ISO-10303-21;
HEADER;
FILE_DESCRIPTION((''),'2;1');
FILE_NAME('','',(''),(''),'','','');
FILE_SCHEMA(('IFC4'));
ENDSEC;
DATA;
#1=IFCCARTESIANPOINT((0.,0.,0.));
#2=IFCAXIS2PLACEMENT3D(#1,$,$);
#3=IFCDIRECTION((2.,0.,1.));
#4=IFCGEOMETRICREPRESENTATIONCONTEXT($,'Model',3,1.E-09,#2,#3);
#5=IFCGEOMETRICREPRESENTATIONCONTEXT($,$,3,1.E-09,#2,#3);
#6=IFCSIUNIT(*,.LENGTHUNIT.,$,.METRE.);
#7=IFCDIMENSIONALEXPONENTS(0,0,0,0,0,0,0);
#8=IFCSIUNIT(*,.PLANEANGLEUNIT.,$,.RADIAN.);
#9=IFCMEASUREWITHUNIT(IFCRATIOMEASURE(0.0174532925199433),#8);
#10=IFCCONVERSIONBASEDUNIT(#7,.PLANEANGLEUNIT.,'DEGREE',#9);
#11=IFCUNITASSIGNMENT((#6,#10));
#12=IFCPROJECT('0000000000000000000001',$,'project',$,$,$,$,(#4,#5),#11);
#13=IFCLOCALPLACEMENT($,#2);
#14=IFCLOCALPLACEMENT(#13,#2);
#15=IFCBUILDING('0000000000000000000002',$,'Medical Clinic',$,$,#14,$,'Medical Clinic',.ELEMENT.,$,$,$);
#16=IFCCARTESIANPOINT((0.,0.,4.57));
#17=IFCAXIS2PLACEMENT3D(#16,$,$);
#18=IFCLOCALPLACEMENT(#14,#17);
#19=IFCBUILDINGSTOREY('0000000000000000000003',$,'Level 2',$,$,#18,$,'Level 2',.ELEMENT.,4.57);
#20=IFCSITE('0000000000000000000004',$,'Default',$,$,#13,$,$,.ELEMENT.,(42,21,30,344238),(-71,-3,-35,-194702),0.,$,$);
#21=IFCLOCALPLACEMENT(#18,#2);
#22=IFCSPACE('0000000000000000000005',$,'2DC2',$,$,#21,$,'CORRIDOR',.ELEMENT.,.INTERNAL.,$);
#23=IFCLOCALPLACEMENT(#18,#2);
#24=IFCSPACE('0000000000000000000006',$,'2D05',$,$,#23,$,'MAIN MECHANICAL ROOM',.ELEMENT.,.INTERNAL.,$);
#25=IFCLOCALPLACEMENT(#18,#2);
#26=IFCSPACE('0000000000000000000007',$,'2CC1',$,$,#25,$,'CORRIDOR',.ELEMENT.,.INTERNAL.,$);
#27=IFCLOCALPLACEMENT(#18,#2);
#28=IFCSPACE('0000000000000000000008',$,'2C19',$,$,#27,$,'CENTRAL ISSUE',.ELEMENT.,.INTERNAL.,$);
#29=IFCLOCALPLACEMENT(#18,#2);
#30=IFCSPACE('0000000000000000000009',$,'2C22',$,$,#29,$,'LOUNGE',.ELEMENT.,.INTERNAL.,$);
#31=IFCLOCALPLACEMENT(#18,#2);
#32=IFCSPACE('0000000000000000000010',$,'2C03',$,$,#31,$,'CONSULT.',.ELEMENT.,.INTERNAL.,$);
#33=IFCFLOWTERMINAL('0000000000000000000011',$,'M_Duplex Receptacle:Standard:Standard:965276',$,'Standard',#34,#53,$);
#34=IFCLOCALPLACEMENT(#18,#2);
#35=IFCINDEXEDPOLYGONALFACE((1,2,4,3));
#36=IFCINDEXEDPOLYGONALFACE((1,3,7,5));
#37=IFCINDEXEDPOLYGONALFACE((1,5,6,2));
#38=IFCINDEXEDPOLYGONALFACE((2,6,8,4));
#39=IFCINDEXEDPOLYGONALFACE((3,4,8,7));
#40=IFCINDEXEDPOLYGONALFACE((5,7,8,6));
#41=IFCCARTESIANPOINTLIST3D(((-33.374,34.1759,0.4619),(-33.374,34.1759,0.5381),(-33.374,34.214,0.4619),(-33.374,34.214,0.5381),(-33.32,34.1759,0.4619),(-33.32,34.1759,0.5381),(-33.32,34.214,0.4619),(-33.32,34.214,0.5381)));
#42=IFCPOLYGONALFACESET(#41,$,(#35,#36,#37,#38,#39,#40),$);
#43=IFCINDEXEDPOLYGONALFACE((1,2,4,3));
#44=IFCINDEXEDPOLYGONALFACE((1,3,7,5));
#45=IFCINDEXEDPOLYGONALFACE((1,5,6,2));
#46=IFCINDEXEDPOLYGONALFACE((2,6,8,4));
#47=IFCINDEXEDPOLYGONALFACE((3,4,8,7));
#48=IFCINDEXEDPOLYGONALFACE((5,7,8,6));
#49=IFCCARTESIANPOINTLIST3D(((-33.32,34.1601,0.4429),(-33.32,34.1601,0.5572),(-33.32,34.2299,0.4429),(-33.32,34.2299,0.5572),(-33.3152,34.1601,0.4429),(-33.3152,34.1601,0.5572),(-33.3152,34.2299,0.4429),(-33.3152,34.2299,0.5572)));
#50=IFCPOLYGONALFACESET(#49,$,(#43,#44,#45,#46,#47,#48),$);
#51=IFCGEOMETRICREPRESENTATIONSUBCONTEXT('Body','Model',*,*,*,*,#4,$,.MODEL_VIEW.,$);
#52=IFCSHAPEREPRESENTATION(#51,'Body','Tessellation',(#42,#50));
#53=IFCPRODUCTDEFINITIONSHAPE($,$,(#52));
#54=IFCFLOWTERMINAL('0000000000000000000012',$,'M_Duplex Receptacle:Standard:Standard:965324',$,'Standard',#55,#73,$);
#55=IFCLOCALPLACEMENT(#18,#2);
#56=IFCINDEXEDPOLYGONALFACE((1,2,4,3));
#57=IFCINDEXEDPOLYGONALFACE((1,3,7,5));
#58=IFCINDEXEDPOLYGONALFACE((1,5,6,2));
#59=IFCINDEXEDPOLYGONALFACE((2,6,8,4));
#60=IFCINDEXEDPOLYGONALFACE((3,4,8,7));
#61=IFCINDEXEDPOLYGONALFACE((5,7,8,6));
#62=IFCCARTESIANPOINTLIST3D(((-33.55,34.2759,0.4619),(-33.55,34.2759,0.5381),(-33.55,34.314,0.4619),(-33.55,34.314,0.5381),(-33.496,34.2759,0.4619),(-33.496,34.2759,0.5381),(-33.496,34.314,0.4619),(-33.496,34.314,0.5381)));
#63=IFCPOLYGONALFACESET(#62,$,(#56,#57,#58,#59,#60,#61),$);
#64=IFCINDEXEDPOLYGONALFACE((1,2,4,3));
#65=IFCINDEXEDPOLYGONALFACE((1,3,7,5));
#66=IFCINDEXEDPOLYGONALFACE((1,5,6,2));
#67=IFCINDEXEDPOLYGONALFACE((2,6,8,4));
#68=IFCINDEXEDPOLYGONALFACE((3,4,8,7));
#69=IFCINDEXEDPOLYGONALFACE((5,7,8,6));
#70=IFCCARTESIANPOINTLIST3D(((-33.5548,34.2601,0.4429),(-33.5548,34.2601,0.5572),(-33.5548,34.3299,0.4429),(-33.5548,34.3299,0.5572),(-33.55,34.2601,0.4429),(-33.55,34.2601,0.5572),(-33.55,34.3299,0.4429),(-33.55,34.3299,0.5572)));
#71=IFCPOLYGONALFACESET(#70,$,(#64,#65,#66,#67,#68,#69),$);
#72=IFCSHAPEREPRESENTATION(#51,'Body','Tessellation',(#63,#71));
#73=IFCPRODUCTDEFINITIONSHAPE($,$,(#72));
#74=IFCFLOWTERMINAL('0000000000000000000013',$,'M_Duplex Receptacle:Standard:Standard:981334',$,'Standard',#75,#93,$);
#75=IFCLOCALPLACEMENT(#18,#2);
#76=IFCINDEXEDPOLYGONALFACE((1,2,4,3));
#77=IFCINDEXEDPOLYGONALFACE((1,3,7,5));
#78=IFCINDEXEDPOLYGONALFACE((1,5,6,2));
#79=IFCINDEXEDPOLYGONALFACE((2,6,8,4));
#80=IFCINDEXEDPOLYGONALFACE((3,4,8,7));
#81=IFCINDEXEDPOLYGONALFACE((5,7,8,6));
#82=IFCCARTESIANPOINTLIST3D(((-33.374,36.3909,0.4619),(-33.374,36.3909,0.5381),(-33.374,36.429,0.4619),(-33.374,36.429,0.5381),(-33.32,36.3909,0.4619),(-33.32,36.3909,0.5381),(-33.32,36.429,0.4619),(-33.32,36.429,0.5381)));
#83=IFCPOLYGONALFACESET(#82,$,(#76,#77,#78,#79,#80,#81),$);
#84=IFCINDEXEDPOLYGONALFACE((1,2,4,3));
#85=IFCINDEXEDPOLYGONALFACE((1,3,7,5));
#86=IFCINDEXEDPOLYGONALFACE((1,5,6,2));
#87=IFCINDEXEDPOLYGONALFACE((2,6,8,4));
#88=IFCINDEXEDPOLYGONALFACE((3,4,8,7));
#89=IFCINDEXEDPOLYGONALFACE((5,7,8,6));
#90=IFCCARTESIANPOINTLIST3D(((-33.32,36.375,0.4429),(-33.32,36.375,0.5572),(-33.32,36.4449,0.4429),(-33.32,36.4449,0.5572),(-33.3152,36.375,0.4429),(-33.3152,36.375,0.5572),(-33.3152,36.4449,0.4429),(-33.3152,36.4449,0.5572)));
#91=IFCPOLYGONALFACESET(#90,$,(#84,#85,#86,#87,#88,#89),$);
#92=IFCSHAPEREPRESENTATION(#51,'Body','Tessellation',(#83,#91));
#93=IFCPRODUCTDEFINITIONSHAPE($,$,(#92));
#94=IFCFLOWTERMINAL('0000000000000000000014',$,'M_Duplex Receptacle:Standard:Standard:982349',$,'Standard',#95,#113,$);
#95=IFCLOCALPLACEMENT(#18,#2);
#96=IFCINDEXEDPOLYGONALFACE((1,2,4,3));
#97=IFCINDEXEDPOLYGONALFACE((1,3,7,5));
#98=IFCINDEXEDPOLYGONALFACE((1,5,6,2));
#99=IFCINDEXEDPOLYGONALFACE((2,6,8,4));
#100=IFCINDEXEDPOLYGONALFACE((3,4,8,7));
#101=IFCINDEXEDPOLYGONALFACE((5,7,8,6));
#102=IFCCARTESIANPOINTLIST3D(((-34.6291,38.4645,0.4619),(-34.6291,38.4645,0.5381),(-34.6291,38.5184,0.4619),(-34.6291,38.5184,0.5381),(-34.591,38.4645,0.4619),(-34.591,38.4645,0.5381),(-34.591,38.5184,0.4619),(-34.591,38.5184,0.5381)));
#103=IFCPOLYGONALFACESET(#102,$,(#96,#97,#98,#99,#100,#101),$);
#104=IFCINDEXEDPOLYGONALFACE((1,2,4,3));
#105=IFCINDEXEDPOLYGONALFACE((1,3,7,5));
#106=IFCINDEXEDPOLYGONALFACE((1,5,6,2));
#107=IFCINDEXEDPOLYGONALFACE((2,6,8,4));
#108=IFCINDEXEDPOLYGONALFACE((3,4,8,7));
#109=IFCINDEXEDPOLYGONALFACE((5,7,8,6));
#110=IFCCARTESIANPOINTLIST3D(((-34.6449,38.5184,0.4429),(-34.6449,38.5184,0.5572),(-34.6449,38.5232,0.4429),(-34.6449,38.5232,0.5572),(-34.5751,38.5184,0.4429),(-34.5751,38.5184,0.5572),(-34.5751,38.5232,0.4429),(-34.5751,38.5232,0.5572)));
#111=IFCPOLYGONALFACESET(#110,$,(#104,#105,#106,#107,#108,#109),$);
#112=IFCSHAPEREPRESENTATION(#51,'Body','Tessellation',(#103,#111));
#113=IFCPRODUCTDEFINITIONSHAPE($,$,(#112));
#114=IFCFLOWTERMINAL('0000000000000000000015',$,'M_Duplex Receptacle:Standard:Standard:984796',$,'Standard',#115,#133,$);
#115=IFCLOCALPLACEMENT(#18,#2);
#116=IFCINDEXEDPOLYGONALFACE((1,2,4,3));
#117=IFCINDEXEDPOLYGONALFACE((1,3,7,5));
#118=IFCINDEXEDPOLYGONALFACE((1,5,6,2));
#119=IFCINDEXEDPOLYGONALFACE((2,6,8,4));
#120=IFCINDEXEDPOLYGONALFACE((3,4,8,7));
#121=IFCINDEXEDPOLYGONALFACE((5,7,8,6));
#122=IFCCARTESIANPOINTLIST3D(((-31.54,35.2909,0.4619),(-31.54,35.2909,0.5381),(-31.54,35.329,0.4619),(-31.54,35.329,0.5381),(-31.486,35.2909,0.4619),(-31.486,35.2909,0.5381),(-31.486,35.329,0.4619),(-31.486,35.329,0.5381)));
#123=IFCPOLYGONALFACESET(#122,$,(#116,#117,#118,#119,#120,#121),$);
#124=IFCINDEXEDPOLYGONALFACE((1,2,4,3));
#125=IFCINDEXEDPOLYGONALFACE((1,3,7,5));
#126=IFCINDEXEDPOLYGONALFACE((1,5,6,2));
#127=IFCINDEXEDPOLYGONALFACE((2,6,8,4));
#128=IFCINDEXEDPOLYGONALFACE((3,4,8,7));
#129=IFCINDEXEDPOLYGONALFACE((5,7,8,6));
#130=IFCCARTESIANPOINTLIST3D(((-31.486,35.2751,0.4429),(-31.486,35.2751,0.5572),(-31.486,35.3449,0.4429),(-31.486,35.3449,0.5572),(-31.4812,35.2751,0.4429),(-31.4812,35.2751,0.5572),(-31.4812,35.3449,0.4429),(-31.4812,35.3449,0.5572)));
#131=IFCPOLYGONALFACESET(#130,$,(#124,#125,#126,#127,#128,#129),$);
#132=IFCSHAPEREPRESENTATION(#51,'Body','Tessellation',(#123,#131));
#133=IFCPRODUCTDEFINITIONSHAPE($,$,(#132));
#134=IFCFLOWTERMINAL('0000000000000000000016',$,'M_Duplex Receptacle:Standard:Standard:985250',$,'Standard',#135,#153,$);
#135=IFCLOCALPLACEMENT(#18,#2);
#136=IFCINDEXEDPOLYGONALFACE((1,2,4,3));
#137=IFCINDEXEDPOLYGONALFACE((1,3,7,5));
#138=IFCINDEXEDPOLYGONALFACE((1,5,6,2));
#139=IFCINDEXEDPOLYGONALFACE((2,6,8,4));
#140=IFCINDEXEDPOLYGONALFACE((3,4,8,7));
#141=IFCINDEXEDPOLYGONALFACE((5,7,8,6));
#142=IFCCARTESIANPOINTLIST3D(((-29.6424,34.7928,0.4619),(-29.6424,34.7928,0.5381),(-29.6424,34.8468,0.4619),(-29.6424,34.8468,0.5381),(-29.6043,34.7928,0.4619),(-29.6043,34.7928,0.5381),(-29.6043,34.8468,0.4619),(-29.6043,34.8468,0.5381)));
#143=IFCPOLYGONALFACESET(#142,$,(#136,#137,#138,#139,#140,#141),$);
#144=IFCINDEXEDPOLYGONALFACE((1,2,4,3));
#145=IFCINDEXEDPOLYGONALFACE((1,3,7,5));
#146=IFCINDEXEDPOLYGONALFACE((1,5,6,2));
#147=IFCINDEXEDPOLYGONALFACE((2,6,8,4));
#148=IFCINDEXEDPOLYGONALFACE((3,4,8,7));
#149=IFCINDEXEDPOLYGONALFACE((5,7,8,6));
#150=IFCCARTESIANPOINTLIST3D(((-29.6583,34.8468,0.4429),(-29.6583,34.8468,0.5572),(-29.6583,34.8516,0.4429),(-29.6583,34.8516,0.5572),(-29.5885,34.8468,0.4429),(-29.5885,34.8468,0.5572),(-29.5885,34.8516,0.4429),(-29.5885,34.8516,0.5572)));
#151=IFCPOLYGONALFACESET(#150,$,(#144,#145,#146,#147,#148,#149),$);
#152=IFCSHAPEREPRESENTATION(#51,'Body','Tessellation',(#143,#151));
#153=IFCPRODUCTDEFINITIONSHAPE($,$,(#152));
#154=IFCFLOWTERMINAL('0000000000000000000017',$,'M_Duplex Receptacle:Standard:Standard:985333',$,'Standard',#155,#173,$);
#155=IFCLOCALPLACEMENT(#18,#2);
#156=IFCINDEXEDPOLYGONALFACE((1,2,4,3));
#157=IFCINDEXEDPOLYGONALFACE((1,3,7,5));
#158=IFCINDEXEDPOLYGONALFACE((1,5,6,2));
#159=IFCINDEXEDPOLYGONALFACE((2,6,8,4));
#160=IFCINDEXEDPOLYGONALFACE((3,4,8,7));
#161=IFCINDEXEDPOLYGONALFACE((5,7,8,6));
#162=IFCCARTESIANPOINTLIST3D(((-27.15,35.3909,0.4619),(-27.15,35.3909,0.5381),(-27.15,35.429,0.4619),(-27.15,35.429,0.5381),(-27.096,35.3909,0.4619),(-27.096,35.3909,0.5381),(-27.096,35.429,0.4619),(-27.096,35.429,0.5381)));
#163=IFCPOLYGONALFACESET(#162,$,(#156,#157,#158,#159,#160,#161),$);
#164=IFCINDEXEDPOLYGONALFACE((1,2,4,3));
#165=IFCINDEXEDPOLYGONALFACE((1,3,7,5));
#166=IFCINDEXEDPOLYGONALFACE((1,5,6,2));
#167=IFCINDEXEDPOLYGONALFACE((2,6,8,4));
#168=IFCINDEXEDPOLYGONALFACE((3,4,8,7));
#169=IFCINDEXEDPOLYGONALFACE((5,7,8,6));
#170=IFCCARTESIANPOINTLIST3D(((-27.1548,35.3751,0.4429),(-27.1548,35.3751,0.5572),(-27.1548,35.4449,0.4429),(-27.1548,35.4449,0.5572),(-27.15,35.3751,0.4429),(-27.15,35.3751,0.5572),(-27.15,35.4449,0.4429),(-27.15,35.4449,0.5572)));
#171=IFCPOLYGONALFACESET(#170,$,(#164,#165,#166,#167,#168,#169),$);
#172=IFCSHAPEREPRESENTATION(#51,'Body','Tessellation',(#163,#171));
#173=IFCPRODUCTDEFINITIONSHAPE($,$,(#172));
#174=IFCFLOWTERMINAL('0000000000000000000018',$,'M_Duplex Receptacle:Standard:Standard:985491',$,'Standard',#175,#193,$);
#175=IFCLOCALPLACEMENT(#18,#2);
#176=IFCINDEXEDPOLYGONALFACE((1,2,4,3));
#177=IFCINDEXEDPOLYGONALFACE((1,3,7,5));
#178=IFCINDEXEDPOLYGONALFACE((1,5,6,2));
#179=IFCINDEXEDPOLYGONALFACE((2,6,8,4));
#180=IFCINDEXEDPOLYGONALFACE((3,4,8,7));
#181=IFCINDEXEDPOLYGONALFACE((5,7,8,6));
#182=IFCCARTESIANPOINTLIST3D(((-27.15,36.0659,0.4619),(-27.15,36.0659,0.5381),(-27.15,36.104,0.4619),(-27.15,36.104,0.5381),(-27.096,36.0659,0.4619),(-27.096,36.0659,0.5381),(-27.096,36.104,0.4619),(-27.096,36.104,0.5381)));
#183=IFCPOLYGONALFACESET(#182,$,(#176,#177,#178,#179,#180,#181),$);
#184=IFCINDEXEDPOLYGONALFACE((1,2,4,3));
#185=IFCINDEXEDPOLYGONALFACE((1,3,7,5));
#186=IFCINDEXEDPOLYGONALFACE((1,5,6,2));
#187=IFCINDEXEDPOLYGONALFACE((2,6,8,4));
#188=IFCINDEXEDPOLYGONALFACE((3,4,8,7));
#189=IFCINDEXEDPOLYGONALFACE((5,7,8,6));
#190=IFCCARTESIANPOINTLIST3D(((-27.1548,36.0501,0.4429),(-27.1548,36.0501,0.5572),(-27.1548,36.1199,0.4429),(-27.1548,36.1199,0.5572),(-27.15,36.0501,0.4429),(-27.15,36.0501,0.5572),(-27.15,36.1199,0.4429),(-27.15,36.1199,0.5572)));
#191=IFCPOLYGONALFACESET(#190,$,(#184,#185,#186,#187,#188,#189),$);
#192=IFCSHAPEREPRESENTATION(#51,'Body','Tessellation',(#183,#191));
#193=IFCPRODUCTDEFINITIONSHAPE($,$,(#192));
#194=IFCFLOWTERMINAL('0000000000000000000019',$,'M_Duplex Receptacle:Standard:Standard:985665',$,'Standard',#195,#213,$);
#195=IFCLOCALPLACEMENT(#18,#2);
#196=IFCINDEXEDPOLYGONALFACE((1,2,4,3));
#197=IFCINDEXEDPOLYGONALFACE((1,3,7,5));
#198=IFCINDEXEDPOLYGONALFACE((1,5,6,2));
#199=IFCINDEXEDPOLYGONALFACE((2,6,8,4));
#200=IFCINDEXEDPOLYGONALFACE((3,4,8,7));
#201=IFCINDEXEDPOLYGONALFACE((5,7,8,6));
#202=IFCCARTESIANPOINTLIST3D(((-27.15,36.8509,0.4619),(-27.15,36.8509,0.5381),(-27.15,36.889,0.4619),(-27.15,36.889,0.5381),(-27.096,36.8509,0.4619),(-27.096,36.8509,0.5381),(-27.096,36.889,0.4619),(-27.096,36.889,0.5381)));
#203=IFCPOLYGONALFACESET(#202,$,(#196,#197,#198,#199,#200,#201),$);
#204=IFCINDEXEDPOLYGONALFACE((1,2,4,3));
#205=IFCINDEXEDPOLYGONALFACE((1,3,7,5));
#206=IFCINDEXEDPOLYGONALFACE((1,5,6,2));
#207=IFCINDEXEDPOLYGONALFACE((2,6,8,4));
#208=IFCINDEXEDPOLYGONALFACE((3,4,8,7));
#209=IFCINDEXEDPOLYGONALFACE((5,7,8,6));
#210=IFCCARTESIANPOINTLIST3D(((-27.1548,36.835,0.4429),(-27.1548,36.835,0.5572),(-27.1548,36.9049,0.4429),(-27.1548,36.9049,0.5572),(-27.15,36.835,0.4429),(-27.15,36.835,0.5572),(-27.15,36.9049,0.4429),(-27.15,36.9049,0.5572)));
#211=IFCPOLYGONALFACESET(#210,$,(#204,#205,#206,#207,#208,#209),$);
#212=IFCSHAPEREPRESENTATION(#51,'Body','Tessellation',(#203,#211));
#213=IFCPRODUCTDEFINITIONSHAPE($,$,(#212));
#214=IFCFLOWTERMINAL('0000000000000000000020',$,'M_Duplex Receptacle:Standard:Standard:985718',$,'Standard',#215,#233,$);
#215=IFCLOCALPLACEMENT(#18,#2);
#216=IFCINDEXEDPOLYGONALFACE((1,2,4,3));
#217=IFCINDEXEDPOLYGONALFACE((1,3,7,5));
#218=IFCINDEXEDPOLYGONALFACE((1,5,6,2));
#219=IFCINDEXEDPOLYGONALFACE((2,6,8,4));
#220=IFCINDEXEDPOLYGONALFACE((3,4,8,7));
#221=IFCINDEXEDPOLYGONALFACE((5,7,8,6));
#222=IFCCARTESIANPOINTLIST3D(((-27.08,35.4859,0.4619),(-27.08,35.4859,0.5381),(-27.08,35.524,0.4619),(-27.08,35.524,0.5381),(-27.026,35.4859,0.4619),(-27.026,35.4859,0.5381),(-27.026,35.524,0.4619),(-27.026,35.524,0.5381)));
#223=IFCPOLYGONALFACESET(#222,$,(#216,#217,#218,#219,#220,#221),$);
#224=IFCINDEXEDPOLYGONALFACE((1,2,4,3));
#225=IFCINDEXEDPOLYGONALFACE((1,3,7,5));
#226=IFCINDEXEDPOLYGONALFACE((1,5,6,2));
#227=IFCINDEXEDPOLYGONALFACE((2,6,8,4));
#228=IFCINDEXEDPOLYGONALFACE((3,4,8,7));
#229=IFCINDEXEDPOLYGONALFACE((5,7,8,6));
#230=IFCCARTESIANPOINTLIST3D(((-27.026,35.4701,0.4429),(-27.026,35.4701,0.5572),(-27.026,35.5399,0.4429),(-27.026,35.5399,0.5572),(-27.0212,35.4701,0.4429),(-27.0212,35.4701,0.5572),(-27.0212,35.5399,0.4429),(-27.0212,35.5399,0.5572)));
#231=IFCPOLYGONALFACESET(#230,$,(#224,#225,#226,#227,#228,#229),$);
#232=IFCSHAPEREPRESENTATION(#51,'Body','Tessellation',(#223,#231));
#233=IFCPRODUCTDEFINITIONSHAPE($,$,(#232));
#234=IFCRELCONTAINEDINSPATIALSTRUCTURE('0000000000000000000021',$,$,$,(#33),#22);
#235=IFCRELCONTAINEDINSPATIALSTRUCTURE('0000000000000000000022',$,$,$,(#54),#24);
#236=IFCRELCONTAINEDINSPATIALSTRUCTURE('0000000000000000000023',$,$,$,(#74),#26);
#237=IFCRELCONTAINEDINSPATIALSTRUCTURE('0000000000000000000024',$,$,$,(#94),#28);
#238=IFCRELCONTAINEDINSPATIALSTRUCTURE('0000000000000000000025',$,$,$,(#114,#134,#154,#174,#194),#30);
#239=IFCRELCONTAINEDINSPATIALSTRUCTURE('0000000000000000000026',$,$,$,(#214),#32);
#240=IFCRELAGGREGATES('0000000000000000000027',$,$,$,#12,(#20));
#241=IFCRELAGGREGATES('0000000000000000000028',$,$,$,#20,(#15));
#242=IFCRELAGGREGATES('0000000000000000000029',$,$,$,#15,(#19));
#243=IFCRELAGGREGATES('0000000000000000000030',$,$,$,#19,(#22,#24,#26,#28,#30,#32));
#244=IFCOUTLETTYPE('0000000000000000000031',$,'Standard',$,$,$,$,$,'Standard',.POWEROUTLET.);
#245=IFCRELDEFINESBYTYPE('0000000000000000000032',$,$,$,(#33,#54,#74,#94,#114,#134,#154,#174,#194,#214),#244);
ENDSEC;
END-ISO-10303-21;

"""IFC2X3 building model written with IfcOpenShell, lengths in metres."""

from ifc_helpers import new_model, entity, si_unit, converted_unit, direction, frame, frame_2d, origin, origin_2d_with_axis, place, context, subcontext, project, spatial, rectangle, extrude, source, transform, mapped, type_object, type_shapes, element, save


model = new_model("IFC2X3")

# Units and contexts
model_context = context("Model", 3, precision=1e-09, world=origin(), true_north=direction((2.0, 0.0, 1.0)))
context_of_model = context(None, 3, precision=1e-09, world=origin(), true_north=direction((2.0, 0.0, 1.0)))
body_context = subcontext(model_context, "Body", "Model", "MODEL_VIEW")
ifc_project = project(units=[si_unit("LENGTHUNIT", "METRE"), converted_unit("PLANEANGLEUNIT", "DEGREE", entity("IfcRatioMeasure", 0.0174532925199433), si_unit("PLANEANGLEUNIT", "RADIAN"), dimensions=[0, 0, 0, 0, 0, 0, 0])], contexts=[model_context, context_of_model])

# Site, building, storey, space
site_placement = place(None, origin())
site = spatial("IfcSite", under=ifc_project, at=site_placement, Name="Default", CompositionType="ELEMENT", RefLatitude=(42, 21, 30, 344238), RefLongitude=(-71, -3, -35, -194702), RefElevation=0.0)
building_placement = place(site_placement, origin())
building = spatial("IfcBuilding", under=site, at=building_placement, Name="Medical Clinic", LongName="Medical Clinic", CompositionType="ELEMENT")
storey_placement = place(building_placement, frame((0.0, 0.0, 4.57)))
storey = spatial("IfcBuildingStorey", under=building, at=storey_placement, Name="Level 2", LongName="Level 2", CompositionType="ELEMENT", Elevation=4.57)
space_1_placement = place(storey_placement, origin())
space_1 = spatial("IfcSpace", under=storey, at=space_1_placement, Name="2DC2", LongName="CORRIDOR", CompositionType="ELEMENT", InteriorOrExteriorSpace="INTERNAL")

# Flow terminal
outlet_type = type_object("IfcOutletType", Name="Standard", ElementType="Standard", PredefinedType="POWEROUTLET")
shared_shape_1 = source(origin(), body_context, "Body", "SweptSolid", [
    extrude(rectangle(XDim=0.0381, YDim=0.0762, at=origin_2d_with_axis()), frame((0.0, 0.0, -0.054), z_axis=(0.0, 0.0, 1.0), x_axis=(-1.0, 0.0, 0.0)), (0.0, 0.0, 1.0), 0.054),
    extrude(rectangle(XDim=0.0698, YDim=0.1143, at=frame_2d((0.0, 0.0), x_axis=(1.0, 0.0))), frame((0.0, 0.0, 0.0), z_axis=(0.0, 0.0, 1.0), x_axis=(-1.0, 0.0, 0.0)), (0.0, 0.0, 1.0), 0.0048),
])
type_shapes(outlet_type, [shared_shape_1])
flow_terminal_1_placement = place(space_1_placement, frame((-33.32, 34.195, 0.5), z_axis=(1.0, 0.0, 0.0), x_axis=(0.0, 1.0, 0.0)))
element("IfcFlowTerminal", 1, at=flow_terminal_1_placement, inside=space_1, type_object=outlet_type, Name="M_Duplex Receptacle:Standard:Standard:965276", ObjectType="Standard", context=body_context, shape_type="MappedRepresentation", body=[
    mapped(shared_shape_1, transform((0.0, 0.0, 0.0), scale=1.0)),
])

# Shared definitions
space_2_placement = place(storey_placement, origin())
space_2 = spatial("IfcSpace", under=storey, at=space_2_placement, Name="2D05", LongName="MAIN MECHANICAL ROOM", CompositionType="ELEMENT", InteriorOrExteriorSpace="INTERNAL")

# Flow terminal
flow_terminal_2_placement = place(space_2_placement, frame((-33.55, 34.295, 0.5), z_axis=(-1.0, 0.0, 0.0), x_axis=(0.0, -1.0, 0.0)))
element("IfcFlowTerminal", 2, at=flow_terminal_2_placement, inside=space_2, type_object=outlet_type, Name="M_Duplex Receptacle:Standard:Standard:965324", ObjectType="Standard", context=body_context, shape_type="MappedRepresentation", body=[
    mapped(shared_shape_1, transform((0.0, 0.0, 0.0), scale=1.0)),
])

# Shared definitions
space_3_placement = place(storey_placement, origin())
space_3 = spatial("IfcSpace", under=storey, at=space_3_placement, Name="2CC1", LongName="CORRIDOR", CompositionType="ELEMENT", InteriorOrExteriorSpace="INTERNAL")

# Flow terminal
flow_terminal_3_placement = place(space_3_placement, frame((-33.32, 36.4099, 0.5), z_axis=(1.0, 0.0, 0.0), x_axis=(0.0, 1.0, 0.0)))
element("IfcFlowTerminal", 3, at=flow_terminal_3_placement, inside=space_3, type_object=outlet_type, Name="M_Duplex Receptacle:Standard:Standard:981334", ObjectType="Standard", context=body_context, shape_type="MappedRepresentation", body=[
    mapped(shared_shape_1, transform((0.0, 0.0, 0.0), scale=1.0)),
])

# Shared definitions
space_4_placement = place(storey_placement, origin())
space_4 = spatial("IfcSpace", under=storey, at=space_4_placement, Name="2C19", LongName="CENTRAL ISSUE", CompositionType="ELEMENT", InteriorOrExteriorSpace="INTERNAL")

# Flow terminal
flow_terminal_4_placement = place(space_4_placement, frame((-34.61, 38.5184, 0.5), z_axis=(0.0, 1.0, 0.0), x_axis=(-1.0, 0.0, 0.0)))
element("IfcFlowTerminal", 4, at=flow_terminal_4_placement, inside=space_4, type_object=outlet_type, Name="M_Duplex Receptacle:Standard:Standard:982349", ObjectType="Standard", context=body_context, shape_type="MappedRepresentation", body=[
    mapped(shared_shape_1, transform((0.0, 0.0, 0.0), scale=1.0)),
])

# Shared definitions
space_5_placement = place(storey_placement, origin())
space_5 = spatial("IfcSpace", under=storey, at=space_5_placement, Name="2C22", LongName="LOUNGE", CompositionType="ELEMENT", InteriorOrExteriorSpace="INTERNAL")

# Flow terminals
for number, where, z_axis, x_axis, name in (
    (5, (-31.486, 35.31, 0.5), (1.0, 0.0, 0.0), (0.0, 1.0, 0.0), "M_Duplex Receptacle:Standard:Standard:984796"),
    (6, (-29.6234, 34.8468, 0.5), (0.0, 1.0, 0.0), (-1.0, 0.0, 0.0), "M_Duplex Receptacle:Standard:Standard:985250"),
    (7, (-27.15, 35.41, 0.5), (-1.0, 0.0, 0.0), (0.0, -1.0, 0.0), "M_Duplex Receptacle:Standard:Standard:985333"),
    (8, (-27.15, 36.085, 0.5), (-1.0, 0.0, 0.0), (0.0, -1.0, 0.0), "M_Duplex Receptacle:Standard:Standard:985491"),
    (9, (-27.15, 36.8699, 0.5), (-1.0, 0.0, 0.0), (0.0, -1.0, 0.0), "M_Duplex Receptacle:Standard:Standard:985665"),
):
    element("IfcFlowTerminal", number, at=place(space_5_placement, frame(where, z_axis=z_axis, x_axis=x_axis)), inside=space_5, type_object=outlet_type, Name=name, ObjectType="Standard", context=body_context, shape_type="MappedRepresentation", body=[
        mapped(shared_shape_1, transform((0.0, 0.0, 0.0), scale=1.0)),
    ])

# Shared definitions
space_6_placement = place(storey_placement, origin())
space_6 = spatial("IfcSpace", under=storey, at=space_6_placement, Name="2C03", LongName="CONSULT.", CompositionType="ELEMENT", InteriorOrExteriorSpace="INTERNAL")

# Flow terminal
for number, where, z_axis, x_axis, name in (
    (10, (-27.026, 35.505, 0.5), (1.0, 0.0, 0.0), (0.0, 1.0, 0.0), "M_Duplex Receptacle:Standard:Standard:985718"),
):
    element("IfcFlowTerminal", number, at=place(space_6_placement, frame(where, z_axis=z_axis, x_axis=x_axis)), inside=space_6, type_object=outlet_type, Name=name, ObjectType="Standard", context=body_context, shape_type="MappedRepresentation", body=[
        mapped(shared_shape_1, transform((0.0, 0.0, 0.0), scale=1.0)),
    ])

save(model, "model.ifc")
